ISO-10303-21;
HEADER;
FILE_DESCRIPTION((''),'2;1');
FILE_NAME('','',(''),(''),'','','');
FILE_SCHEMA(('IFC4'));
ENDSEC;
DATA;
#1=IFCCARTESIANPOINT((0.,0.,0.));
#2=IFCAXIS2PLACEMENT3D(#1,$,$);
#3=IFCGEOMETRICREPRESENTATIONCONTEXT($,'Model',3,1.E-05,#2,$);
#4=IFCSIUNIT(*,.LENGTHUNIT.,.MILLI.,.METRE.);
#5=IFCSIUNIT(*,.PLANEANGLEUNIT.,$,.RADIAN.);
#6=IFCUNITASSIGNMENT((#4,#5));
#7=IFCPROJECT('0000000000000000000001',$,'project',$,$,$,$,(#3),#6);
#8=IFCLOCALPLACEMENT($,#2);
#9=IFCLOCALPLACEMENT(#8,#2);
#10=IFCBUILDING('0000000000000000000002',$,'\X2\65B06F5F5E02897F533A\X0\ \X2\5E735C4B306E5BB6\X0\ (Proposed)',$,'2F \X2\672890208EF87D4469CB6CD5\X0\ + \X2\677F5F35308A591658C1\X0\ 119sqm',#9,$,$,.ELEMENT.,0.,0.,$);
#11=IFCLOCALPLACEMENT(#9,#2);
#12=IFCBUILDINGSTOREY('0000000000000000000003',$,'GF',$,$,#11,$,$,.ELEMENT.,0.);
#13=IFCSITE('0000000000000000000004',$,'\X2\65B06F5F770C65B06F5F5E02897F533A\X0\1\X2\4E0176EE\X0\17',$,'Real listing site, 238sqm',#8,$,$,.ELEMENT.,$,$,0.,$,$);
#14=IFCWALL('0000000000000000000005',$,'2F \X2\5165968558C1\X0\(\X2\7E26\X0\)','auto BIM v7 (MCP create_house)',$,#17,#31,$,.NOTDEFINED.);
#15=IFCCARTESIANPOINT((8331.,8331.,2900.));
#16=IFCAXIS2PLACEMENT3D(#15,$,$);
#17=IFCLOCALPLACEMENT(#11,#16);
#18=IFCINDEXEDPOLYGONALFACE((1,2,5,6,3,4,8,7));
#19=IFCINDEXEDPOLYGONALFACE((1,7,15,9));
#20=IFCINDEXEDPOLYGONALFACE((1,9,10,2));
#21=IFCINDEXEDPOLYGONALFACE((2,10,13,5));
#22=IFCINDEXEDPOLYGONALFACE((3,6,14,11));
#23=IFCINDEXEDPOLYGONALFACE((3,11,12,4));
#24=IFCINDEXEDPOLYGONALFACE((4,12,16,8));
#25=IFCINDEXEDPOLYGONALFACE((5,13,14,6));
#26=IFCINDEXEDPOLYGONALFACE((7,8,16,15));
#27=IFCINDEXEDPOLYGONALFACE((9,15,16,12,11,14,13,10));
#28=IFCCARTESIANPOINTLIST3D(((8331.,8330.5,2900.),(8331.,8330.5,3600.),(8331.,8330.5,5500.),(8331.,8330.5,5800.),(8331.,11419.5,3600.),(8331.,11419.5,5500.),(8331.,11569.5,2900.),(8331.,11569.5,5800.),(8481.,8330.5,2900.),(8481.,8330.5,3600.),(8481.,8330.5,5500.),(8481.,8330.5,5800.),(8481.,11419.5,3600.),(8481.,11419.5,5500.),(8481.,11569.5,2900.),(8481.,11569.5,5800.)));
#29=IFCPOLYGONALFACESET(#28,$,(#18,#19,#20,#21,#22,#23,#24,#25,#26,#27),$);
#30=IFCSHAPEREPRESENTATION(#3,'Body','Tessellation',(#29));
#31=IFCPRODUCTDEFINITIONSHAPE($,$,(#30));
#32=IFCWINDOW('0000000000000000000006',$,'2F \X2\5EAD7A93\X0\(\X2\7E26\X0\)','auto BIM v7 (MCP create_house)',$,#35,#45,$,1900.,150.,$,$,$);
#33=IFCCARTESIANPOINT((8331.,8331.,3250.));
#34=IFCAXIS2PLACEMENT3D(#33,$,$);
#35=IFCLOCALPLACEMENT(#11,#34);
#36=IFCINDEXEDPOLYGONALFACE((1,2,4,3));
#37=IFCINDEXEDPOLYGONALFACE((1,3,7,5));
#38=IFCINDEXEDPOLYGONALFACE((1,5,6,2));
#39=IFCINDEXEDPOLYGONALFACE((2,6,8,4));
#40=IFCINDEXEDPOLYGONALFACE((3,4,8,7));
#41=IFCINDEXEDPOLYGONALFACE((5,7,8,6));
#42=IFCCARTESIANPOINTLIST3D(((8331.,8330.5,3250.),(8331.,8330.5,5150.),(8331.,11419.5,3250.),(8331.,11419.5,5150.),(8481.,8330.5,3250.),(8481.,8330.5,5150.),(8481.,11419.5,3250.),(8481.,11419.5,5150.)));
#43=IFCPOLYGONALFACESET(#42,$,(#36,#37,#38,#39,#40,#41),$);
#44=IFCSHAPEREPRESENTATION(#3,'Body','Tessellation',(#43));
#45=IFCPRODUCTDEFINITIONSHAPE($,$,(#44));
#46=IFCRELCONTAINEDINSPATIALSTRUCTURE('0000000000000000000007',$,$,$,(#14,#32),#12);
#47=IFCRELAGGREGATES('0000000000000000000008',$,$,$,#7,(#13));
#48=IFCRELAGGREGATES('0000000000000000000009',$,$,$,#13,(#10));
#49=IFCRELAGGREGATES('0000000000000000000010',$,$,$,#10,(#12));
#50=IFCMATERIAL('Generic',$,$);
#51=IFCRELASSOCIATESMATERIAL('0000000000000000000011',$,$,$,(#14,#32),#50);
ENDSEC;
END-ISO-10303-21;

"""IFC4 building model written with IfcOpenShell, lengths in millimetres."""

from ifc_helpers import new_model, si_unit, frame, frame_2d, origin, place, context, project, spatial, rectangle, extrude, material, element, fill, save


model = new_model("IFC4")

# Units and contexts
model_context = context("Model", 3, precision=1e-05, world=origin())
ifc_project = project(units=[si_unit("LENGTHUNIT", "METRE", prefix="MILLI"), si_unit("PLANEANGLEUNIT", "RADIAN")], contexts=[model_context])

# Site, building, storey
site_placement = place(None, origin())
site = spatial("IfcSite", under=ifc_project, at=site_placement, Name="新潟県新潟市西区1丁目17", ObjectType="Real listing site, 238sqm", CompositionType="ELEMENT", RefElevation=0.0)
building_placement = place(site_placement, origin())
building = spatial("IfcBuilding", under=site, at=building_placement, Name="新潟市西区 平屋の家 (Proposed)", ObjectType="2F 木造軸組構法 + 板張り外壁 119sqm", CompositionType="ELEMENT", ElevationOfRefHeight=0.0, ElevationOfTerrain=0.0)
storey_placement = place(building_placement, origin())
storey = spatial("IfcBuildingStorey", under=building, at=storey_placement, Name="GF", CompositionType="ELEMENT", Elevation=0.0)

# Shared definitions
ifc_material = material(Name="Generic")

# Wall, opening, window
wall_1_placement = place(storey_placement, frame((8331.0, 8331.0, 2900.0)))
wall_1 = element("IfcWall", 1, at=wall_1_placement, inside=storey, material=ifc_material, Name="2F 入隅壁(縦)", Description="auto BIM v7 (MCP create_house)", PredefinedType="NOTDEFINED", context=model_context, shape_type="SweptSolid", body=[
    extrude(rectangle(XDim=150.0, YDim=3239.0, at=frame_2d((75.0, 1619.0))), frame((8331.0, 8331.0, 2900.0)), (0.0, 0.0, 1.0), 2900.0),
])
opening_1_placement = place(storey_placement, frame((8331.0, 8331.0, 3250.0)))
opening_1 = element("IfcOpeningElement", 2, at=opening_1_placement, cuts=wall_1, PredefinedType="NOTDEFINED", context=model_context, shape_type="SweptSolid", body=[
    extrude(rectangle(XDim=150.0, YDim=3089.0, at=frame_2d((75.0, 1544.0))), frame((8331.0, 8331.0, 3250.0)), (0.0, 0.0, 1.0), 1900.0),
])
window_1_placement = place(storey_placement, frame((8331.0, 8331.0, 3250.0)))
window_1 = element("IfcWindow", 3, at=window_1_placement, inside=storey, material=ifc_material, Name="2F 庭窓(縦)", Description="auto BIM v7 (MCP create_house)", OverallHeight=1900.0, OverallWidth=150.0, context=model_context, shape_type="SweptSolid", body=[
    extrude(rectangle(XDim=150.0, YDim=3089.0, at=frame_2d((75.0, 1544.0))), frame((8331.0, 8331.0, 3250.0)), (0.0, 0.0, 1.0), 1900.0),
])
fill(opening_1, window_1)

save(model, "model.ifc")
